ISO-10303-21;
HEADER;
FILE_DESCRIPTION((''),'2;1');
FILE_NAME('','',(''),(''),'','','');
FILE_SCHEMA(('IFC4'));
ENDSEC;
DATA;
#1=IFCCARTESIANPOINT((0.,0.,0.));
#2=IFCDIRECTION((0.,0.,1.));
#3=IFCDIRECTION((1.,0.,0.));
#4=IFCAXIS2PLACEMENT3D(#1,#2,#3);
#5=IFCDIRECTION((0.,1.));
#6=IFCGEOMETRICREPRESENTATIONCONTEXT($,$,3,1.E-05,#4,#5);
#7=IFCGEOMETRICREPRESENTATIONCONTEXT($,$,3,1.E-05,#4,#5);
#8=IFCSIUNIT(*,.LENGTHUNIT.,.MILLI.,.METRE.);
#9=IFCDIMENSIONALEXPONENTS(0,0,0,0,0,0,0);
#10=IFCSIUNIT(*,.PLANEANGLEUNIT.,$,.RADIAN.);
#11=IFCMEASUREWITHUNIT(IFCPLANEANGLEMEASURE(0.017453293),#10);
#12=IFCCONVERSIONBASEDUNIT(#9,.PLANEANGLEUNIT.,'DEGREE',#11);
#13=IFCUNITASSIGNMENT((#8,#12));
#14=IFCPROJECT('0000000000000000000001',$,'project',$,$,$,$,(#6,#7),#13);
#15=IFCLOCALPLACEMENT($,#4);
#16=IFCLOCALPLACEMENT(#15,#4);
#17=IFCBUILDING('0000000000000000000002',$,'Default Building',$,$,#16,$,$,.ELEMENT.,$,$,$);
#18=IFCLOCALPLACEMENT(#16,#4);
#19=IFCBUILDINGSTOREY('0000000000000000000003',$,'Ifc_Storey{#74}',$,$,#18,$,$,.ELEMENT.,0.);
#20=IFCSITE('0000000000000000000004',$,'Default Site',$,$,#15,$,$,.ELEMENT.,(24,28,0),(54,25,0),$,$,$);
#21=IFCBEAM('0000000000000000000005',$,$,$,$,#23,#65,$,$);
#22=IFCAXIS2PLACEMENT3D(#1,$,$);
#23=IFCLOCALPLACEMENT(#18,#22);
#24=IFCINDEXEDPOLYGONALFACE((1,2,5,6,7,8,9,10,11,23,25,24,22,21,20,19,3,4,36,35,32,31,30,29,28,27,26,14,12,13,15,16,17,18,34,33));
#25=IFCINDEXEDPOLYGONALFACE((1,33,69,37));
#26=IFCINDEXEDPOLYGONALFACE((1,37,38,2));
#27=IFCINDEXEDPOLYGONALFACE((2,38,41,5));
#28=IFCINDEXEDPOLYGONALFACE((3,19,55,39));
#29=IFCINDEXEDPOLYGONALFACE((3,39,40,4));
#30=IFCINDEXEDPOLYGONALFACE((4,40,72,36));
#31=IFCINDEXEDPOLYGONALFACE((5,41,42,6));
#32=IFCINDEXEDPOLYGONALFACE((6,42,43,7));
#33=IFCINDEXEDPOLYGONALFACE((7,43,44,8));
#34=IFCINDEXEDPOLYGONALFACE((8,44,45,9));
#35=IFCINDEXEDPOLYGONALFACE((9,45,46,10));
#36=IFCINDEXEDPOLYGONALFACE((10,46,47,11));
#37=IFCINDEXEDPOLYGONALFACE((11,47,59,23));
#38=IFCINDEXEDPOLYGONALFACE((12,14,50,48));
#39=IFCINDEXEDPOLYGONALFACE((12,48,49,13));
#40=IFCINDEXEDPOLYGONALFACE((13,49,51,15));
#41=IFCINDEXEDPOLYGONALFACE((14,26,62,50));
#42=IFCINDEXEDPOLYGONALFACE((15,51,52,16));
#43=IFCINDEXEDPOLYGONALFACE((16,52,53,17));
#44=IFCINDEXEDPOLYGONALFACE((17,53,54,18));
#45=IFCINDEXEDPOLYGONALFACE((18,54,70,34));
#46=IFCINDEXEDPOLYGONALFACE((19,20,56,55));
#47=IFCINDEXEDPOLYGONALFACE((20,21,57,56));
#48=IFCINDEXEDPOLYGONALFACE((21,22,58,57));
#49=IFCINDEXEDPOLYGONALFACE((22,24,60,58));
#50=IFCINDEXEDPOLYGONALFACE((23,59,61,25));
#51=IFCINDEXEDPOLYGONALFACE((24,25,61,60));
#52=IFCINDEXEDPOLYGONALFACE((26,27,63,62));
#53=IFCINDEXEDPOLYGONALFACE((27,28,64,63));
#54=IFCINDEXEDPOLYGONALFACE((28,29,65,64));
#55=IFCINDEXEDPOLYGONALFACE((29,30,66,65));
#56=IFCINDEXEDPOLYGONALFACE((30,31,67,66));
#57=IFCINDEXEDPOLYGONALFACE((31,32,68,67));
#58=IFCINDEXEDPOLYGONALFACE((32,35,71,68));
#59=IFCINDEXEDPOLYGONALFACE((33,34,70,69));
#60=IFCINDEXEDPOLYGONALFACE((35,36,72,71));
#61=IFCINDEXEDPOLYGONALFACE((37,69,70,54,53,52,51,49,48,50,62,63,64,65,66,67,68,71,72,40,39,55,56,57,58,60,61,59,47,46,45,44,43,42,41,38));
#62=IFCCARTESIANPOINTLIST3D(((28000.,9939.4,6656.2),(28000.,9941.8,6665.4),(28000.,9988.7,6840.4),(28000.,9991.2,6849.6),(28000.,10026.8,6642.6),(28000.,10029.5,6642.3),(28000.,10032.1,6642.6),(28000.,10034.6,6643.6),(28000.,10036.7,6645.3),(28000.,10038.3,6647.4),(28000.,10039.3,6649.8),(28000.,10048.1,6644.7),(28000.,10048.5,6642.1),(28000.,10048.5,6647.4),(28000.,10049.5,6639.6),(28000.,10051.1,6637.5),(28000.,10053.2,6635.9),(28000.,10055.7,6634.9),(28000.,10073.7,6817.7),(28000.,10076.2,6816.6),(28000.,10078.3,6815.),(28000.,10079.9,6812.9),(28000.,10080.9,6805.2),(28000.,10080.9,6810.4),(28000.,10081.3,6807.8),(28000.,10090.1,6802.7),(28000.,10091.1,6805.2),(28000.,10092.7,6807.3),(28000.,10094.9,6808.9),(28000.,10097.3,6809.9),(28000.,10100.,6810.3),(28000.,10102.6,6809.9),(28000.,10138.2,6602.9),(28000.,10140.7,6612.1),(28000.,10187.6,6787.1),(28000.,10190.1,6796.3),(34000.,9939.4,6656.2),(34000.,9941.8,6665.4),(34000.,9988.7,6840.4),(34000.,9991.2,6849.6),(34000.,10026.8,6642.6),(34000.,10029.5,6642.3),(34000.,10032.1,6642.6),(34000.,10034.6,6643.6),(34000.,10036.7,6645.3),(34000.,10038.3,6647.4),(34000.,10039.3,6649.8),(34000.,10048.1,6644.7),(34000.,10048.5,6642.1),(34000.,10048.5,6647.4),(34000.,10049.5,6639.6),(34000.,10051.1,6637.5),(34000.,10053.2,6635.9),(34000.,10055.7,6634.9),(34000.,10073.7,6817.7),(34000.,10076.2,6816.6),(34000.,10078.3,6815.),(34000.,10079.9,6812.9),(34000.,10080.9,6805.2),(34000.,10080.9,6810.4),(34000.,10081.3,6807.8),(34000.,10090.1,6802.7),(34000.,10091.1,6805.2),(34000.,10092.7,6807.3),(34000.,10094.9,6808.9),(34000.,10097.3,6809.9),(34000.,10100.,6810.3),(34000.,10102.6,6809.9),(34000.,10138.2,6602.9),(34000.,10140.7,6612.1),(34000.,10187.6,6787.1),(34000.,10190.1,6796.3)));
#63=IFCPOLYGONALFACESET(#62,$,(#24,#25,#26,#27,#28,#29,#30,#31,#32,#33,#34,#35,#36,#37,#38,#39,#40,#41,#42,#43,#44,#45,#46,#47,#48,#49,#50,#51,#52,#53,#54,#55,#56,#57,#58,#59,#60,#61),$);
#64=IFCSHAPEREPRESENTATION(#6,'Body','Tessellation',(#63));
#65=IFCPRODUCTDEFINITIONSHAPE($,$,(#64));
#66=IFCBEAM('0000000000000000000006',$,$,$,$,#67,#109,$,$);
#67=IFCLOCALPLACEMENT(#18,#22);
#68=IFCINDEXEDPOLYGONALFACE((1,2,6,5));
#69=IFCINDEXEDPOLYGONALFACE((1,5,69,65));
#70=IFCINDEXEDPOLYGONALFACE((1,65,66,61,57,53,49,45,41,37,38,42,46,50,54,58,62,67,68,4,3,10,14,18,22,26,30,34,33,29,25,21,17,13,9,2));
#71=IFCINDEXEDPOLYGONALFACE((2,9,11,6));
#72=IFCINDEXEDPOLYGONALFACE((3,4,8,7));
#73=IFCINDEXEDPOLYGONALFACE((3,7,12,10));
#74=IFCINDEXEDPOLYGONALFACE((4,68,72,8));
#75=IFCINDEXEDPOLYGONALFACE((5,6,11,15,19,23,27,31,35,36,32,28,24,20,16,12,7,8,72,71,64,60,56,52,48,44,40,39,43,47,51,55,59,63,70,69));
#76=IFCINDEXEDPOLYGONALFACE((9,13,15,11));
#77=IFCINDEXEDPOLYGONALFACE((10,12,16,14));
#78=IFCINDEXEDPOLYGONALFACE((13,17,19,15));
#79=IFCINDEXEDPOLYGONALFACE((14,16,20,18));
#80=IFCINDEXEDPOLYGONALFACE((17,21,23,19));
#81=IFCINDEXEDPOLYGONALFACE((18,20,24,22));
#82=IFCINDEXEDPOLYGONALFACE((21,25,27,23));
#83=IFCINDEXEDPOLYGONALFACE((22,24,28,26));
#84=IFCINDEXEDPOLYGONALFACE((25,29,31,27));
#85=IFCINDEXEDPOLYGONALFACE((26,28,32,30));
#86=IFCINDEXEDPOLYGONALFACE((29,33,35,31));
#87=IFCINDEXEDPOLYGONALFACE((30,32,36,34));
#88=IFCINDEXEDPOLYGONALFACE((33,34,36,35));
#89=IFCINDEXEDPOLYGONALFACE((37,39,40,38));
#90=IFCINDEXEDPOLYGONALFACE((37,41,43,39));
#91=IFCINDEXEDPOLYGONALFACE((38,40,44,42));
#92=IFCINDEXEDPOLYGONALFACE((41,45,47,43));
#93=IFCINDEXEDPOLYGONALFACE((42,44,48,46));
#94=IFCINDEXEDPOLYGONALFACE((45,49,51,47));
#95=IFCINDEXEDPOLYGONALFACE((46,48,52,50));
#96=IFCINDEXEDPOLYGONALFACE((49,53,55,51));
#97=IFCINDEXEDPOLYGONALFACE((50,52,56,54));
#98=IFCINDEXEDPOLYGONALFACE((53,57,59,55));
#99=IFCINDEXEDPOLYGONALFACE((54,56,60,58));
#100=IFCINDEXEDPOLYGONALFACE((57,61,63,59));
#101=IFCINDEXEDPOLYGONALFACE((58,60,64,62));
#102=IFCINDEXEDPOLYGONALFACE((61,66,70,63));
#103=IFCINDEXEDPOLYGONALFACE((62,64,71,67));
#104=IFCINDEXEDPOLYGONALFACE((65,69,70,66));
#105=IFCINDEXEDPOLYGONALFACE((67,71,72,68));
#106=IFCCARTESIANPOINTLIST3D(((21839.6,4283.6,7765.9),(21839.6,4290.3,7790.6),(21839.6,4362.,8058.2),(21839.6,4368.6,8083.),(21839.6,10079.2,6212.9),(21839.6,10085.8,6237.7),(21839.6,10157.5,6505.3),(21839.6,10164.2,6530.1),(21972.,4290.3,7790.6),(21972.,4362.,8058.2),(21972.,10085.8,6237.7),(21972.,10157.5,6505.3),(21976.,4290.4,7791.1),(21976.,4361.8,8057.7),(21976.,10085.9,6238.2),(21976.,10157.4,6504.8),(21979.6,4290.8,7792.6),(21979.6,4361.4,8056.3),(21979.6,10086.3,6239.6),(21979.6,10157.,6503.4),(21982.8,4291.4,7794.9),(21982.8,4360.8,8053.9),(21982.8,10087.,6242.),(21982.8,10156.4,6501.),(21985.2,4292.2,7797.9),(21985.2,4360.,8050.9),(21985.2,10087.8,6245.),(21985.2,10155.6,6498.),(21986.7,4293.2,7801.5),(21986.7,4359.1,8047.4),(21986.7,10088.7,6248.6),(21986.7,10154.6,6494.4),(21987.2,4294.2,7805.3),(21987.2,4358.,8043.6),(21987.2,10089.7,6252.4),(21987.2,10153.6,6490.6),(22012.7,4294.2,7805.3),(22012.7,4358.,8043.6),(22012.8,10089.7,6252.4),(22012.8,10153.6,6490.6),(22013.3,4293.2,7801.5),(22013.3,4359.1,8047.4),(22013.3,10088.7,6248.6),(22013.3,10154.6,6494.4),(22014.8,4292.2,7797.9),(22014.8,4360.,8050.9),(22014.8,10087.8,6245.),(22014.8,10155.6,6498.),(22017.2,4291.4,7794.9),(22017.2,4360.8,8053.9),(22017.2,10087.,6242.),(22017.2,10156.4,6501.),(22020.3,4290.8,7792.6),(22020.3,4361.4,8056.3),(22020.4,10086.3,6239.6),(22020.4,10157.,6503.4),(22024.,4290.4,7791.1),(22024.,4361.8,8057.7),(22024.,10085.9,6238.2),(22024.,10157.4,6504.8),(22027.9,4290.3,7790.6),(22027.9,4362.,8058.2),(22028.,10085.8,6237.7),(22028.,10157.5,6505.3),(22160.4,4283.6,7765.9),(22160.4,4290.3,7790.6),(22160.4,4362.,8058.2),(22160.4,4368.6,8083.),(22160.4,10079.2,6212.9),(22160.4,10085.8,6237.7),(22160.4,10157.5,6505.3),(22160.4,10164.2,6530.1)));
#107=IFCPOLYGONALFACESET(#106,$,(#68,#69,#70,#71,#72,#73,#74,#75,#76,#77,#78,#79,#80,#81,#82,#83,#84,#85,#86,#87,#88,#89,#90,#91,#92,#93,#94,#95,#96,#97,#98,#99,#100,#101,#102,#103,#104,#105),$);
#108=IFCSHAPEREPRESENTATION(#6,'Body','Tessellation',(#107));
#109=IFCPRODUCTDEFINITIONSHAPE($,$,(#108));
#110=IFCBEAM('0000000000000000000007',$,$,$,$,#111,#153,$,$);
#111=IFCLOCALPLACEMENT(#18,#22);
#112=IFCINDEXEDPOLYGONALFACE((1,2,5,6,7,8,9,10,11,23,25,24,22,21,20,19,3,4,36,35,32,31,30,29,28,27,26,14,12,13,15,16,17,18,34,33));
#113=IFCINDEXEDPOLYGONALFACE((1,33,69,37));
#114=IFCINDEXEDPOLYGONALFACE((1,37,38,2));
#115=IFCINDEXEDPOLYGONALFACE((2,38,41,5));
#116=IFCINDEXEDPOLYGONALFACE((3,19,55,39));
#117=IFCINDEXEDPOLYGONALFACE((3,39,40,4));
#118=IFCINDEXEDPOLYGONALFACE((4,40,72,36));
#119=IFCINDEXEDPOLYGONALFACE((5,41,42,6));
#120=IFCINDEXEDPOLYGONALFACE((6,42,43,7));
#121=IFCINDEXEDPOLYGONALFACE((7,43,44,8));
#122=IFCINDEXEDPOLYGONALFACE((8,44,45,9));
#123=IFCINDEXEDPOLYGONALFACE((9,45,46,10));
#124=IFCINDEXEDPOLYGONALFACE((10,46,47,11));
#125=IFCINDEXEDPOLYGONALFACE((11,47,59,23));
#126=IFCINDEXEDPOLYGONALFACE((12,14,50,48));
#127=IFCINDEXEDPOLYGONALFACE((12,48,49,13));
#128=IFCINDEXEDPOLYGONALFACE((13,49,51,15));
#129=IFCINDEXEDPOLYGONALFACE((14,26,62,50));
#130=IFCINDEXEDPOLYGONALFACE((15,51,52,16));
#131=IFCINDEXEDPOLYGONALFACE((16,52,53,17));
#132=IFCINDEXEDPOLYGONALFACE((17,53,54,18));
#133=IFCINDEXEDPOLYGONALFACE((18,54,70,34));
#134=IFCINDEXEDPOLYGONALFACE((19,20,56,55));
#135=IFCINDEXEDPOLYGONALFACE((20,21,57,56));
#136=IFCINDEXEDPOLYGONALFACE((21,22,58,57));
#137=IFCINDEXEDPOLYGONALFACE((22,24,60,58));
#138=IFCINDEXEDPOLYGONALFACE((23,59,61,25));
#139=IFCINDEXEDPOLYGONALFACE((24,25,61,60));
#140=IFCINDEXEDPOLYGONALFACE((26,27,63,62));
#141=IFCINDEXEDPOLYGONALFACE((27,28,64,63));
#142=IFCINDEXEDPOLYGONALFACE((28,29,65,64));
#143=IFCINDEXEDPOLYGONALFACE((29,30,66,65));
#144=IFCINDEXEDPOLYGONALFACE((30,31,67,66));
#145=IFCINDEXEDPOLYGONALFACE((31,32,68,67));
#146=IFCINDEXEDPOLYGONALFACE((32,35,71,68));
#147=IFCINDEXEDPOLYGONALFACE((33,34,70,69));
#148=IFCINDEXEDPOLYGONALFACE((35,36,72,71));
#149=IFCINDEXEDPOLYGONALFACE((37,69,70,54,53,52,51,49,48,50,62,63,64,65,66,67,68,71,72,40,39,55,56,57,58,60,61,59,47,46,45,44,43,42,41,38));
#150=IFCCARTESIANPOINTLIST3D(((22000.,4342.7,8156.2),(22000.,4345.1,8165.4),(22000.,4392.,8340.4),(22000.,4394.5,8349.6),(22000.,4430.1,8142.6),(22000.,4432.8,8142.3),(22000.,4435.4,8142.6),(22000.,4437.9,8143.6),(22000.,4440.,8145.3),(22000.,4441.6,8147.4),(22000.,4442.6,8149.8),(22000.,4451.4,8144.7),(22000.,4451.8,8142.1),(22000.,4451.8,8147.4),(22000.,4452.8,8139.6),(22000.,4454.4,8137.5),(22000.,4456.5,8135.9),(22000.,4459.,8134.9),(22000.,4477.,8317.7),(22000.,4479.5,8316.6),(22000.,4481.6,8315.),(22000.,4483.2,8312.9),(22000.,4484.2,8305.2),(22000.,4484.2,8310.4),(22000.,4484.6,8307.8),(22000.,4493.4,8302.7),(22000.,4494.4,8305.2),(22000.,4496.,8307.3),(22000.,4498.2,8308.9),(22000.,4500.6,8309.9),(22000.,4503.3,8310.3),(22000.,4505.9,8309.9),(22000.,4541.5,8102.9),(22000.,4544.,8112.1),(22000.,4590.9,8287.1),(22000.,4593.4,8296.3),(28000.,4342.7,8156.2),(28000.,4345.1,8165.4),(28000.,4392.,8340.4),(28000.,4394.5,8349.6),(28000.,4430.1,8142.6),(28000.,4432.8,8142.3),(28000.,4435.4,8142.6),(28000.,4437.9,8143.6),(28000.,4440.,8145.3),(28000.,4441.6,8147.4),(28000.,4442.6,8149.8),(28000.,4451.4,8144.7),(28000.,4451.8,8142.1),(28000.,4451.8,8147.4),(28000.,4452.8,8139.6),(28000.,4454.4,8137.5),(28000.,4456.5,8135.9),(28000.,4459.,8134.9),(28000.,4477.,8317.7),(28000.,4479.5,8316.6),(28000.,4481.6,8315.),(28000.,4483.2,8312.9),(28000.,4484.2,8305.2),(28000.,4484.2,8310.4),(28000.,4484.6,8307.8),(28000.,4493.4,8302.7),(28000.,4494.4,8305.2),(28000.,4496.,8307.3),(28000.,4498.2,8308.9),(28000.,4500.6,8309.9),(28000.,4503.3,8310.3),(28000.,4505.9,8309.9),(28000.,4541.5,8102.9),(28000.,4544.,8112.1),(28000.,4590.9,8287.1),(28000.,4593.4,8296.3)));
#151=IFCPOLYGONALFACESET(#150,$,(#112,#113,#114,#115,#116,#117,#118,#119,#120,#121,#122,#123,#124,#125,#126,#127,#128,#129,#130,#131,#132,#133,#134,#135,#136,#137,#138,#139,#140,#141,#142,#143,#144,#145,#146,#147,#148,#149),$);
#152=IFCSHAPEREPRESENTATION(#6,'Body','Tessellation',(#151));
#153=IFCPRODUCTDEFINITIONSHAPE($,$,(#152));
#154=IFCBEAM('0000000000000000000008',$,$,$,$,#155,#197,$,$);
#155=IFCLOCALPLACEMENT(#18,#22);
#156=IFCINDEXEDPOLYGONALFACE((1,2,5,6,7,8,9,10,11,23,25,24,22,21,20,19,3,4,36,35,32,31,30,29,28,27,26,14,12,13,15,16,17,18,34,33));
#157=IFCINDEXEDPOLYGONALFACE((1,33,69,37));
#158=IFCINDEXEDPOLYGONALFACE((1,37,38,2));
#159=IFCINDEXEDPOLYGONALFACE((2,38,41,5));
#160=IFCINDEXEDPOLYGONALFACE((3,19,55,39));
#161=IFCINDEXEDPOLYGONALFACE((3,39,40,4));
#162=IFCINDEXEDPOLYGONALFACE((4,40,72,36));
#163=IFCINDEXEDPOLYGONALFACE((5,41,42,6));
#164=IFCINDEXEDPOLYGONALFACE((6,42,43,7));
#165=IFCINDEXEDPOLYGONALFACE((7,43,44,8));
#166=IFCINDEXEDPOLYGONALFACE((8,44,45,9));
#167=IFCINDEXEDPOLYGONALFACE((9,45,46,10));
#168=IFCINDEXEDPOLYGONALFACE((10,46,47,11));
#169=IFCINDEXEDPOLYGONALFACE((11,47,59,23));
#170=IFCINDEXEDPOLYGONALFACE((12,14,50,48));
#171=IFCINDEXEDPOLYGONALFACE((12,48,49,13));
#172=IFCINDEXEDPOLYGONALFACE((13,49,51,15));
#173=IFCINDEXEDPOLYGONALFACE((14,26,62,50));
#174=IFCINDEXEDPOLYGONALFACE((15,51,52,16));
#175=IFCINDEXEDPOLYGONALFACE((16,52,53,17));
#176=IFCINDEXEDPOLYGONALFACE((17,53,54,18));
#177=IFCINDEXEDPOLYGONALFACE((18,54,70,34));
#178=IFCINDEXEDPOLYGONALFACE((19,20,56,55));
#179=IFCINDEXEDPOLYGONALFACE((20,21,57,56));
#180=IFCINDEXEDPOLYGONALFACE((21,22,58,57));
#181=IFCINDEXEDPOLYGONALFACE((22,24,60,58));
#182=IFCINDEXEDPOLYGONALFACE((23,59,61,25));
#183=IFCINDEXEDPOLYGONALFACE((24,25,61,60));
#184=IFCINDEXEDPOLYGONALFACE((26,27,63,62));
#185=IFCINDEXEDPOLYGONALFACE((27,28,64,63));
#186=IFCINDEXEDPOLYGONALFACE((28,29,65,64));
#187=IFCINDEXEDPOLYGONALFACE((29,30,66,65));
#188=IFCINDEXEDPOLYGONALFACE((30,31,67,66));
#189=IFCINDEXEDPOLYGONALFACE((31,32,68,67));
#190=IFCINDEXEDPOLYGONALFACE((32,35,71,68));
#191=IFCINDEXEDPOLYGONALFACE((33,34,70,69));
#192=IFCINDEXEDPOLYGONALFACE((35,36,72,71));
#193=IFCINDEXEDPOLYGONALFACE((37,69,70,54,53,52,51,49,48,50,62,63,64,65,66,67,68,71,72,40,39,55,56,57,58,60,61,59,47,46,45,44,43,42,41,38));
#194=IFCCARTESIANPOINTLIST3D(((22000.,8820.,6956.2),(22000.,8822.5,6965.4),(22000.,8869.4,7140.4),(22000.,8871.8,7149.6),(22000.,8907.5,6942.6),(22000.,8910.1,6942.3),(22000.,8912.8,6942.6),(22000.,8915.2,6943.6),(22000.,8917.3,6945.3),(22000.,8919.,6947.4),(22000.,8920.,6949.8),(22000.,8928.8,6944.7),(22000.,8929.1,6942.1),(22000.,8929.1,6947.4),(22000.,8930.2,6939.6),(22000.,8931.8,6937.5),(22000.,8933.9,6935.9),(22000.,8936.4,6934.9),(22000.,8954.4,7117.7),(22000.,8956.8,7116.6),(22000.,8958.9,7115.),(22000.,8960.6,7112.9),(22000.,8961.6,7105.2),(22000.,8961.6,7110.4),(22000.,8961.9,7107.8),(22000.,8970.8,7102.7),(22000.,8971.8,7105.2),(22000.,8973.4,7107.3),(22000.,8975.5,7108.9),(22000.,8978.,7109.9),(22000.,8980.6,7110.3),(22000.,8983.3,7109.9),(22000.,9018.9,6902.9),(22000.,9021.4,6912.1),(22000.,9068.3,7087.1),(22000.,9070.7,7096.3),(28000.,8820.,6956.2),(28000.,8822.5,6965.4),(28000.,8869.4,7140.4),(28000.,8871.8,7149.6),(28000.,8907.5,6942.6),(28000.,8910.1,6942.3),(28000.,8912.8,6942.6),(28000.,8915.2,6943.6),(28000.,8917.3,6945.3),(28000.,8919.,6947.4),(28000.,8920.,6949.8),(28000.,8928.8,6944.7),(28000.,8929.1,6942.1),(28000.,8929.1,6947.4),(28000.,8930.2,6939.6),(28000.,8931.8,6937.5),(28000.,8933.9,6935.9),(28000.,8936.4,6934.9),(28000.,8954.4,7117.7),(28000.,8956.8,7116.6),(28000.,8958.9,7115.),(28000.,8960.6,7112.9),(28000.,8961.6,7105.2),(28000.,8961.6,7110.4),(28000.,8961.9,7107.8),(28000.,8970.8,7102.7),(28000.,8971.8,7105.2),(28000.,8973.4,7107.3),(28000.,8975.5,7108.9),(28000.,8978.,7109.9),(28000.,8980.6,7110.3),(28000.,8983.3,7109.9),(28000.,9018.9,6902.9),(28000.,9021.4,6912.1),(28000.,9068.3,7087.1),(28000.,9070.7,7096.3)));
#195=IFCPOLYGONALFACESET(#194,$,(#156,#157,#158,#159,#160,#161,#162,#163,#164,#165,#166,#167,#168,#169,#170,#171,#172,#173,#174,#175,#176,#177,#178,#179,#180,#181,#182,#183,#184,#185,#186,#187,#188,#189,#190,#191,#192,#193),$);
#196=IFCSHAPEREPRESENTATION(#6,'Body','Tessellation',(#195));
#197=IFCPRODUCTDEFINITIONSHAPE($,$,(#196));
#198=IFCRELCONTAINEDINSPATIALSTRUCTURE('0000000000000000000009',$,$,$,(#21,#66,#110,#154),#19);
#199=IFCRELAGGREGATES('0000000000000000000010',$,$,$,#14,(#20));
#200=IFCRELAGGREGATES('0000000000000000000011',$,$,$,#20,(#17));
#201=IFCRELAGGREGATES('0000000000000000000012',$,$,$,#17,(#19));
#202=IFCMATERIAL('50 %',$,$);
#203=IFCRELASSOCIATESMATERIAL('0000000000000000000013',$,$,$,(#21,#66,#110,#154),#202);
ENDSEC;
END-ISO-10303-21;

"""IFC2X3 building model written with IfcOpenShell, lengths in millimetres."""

from ifc_helpers import new_model, entity, si_unit, converted_unit, direction, frame, origin_with_axes, origin_2d_with_axis, place, context, project, spatial, i_section, extrude, material, element, save


model = new_model("IFC2X3")

# Units and contexts
context_of_model_1 = context(None, 3, precision=1e-05, world=origin_with_axes(), true_north=direction((0.0, 1.0)))
context_of_model_2 = context(None, 3, precision=1e-05, world=origin_with_axes(), true_north=direction((0.0, 1.0)))
ifc_project = project(units=[si_unit("LENGTHUNIT", "METRE", prefix="MILLI"), converted_unit("PLANEANGLEUNIT", "DEGREE", entity("IfcPlaneAngleMeasure", 0.017453293), si_unit("PLANEANGLEUNIT", "RADIAN"), dimensions=[0, 0, 0, 0, 0, 0, 0])], contexts=[context_of_model_1, context_of_model_2])

# Site, building, storey
site_placement = place(None, origin_with_axes())
site = spatial("IfcSite", under=ifc_project, at=site_placement, Name="Default Site", CompositionType="ELEMENT", RefLatitude=(24, 28, 0), RefLongitude=(54, 25, 0))
building_placement = place(site_placement, origin_with_axes())
building = spatial("IfcBuilding", under=site, at=building_placement, Name="Default Building", CompositionType="ELEMENT")
storey_placement = place(building_placement, origin_with_axes())
storey = spatial("IfcBuildingStorey", under=building, at=storey_placement, Name="Ifc_Storey{#74}", CompositionType="ELEMENT", Elevation=0.0)

# Shared definitions
ifc_material_1 = material(Name="50 %")

# Beams
beam_1_placement = place(storey_placement, frame((28000.0, 10064.7, 6726.3), z_axis=(0.0, 0.258819, 0.965926), x_axis=(1.0, 0.0, 0.0)))
element("IfcBeam", 1, at=beam_1_placement, inside=storey, material=ifc_material_1, context=context_of_model_1, shape_type="SweptSolid", body=[
    extrude(i_section(OverallWidth=205.9, OverallDepth=200.2, WebThickness=9.5, FlangeThickness=9.5, FilletRadius=10.2, at=origin_2d_with_axis()), frame((0.0, 0.0, 0.0), z_axis=(1.0, 0.0, 0.0), x_axis=(0.0, 1.0, 0.0)), (0.0, 0.0, 1.0), 6000.0),
])
beam_2_placement = place(storey_placement, frame((22000.0, 10121.7, 6371.5), z_axis=(0.0, 0.0, 1.0), x_axis=(0.0, -1.0, 0.0)))
element("IfcBeam", 2, at=beam_2_placement, inside=storey, material=ifc_material_1, context=context_of_model_1, shape_type="SweptSolid", body=[
    extrude(i_section(OverallWidth=320.9, OverallDepth=328.3, WebThickness=25.5, FlangeThickness=25.6, FilletRadius=15.2, at=origin_2d_with_axis()), frame((0.0, 0.0, 0.0), z_axis=(0.965926, 0.0, 0.258819), x_axis=(0.0, 1.0, 0.0)), (0.0, 0.0, 1.0), 6000.0),
])
for number, where, z_axis, x_axis in (
    (3, (22000.0, 4468.0, 8226.3), (0.0, 0.258819, 0.965926), (1.0, 0.0, 0.0)),
    (4, (22000.0, 8945.4, 7026.3), (0.0, 0.258819, 0.965926), (1.0, 0.0, 0.0)),
):
    element("IfcBeam", number, at=place(storey_placement, frame(where, z_axis=z_axis, x_axis=x_axis)), inside=storey, material=ifc_material_1, context=context_of_model_1, shape_type="SweptSolid", body=[
        extrude(i_section(OverallWidth=205.9, OverallDepth=200.2, WebThickness=9.5, FlangeThickness=9.5, FilletRadius=10.2, at=origin_2d_with_axis()), frame((0.0, 0.0, 0.0), z_axis=(1.0, 0.0, 0.0), x_axis=(0.0, 1.0, 0.0)), (0.0, 0.0, 1.0), 6000.0),
    ])

save(model, "model.ifc")
